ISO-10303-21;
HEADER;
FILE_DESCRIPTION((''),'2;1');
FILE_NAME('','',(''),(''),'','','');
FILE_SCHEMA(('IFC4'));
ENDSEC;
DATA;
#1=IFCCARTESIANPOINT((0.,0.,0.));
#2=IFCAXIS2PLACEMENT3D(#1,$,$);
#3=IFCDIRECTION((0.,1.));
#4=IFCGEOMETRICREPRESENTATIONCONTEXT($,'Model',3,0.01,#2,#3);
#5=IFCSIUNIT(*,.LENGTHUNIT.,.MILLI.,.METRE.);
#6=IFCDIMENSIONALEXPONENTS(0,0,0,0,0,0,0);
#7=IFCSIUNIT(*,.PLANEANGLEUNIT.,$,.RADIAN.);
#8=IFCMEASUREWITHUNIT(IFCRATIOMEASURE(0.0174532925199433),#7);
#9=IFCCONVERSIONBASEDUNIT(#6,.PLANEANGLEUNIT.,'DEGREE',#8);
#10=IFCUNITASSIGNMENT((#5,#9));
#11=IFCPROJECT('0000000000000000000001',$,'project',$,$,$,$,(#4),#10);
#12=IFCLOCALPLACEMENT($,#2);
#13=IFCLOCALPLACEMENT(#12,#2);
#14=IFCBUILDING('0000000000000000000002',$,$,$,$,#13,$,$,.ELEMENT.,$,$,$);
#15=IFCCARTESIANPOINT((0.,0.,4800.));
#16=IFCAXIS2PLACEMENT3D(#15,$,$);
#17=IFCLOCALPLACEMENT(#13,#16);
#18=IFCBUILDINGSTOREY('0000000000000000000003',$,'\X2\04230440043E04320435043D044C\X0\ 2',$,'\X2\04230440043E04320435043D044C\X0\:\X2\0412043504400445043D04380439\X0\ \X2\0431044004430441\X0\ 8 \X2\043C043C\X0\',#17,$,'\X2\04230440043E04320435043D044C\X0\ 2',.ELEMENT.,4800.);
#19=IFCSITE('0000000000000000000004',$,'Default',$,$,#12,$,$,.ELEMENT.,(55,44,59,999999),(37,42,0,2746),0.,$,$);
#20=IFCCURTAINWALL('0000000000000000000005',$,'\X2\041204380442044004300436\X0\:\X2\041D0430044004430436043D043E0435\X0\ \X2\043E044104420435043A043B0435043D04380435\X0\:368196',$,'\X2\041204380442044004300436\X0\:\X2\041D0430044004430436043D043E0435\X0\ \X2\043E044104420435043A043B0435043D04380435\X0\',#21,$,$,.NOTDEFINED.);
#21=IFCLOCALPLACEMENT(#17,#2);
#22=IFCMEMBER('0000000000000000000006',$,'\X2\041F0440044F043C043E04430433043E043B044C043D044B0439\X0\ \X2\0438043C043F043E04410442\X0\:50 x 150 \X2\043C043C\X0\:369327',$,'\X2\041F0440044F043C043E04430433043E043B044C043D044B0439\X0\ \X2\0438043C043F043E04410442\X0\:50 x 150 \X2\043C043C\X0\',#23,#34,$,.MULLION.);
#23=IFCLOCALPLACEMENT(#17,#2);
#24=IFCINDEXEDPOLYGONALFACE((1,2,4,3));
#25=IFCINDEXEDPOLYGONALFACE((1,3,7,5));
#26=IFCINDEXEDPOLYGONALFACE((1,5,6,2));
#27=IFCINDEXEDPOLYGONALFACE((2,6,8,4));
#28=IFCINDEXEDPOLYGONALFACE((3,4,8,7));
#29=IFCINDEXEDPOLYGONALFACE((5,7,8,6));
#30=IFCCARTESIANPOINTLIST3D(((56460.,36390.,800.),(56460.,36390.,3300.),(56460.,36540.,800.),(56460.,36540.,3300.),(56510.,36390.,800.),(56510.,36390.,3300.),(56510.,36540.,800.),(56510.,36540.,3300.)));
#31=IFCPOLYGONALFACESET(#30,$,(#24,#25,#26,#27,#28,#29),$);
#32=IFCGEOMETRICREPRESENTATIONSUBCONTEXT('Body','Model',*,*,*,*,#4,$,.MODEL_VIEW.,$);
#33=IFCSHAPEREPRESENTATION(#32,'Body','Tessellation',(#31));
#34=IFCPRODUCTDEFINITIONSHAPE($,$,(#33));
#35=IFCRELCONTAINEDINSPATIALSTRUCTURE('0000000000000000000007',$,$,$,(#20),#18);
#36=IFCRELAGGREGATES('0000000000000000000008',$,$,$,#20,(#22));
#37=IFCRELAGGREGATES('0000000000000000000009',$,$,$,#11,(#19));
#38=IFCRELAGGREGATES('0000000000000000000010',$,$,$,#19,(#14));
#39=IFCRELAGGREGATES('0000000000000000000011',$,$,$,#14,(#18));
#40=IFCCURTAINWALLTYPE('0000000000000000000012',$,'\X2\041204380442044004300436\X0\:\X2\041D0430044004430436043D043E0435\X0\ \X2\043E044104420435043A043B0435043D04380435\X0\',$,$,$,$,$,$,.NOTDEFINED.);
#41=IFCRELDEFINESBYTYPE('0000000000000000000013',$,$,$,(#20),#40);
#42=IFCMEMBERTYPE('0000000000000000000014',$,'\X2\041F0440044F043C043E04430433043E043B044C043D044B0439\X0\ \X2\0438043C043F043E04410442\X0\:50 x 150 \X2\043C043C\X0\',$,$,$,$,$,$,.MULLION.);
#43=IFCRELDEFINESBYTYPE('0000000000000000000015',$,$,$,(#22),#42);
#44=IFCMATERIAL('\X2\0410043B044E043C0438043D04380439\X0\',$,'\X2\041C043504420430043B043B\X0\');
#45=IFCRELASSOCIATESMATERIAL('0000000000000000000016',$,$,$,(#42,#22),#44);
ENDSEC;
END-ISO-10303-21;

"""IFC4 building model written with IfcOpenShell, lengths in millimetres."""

from ifc_helpers import new_model, entity, si_unit, converted_unit, direction, frame, origin, origin_2d_with_axis, place, context, subcontext, project, spatial, rectangle, extrude, source, transform, mapped, material, material_profile, profile_set, profile_usage, type_object, type_shapes, element, aggregate, save


model = new_model("IFC4")

# Units and contexts
model_context = context("Model", 3, precision=0.01, world=origin(), true_north=direction((0.0, 1.0)))
body_context = subcontext(model_context, "Body", "Model", "MODEL_VIEW")
ifc_project = project(units=[si_unit("LENGTHUNIT", "METRE", prefix="MILLI"), converted_unit("PLANEANGLEUNIT", "DEGREE", entity("IfcRatioMeasure", 0.0174532925199433), si_unit("PLANEANGLEUNIT", "RADIAN"), dimensions=[0, 0, 0, 0, 0, 0, 0])], contexts=[model_context])

# Site, building, storey
site_placement = place(None, origin())
site = spatial("IfcSite", under=ifc_project, at=site_placement, Name="Default", CompositionType="ELEMENT", RefLatitude=(55, 44, 59, 999999), RefLongitude=(37, 42, 0, 2746), RefElevation=0.0)
building_placement = place(site_placement, origin())
building = spatial("IfcBuilding", under=site, at=building_placement, CompositionType="ELEMENT")
storey_placement = place(building_placement, frame((0.0, 0.0, 4800.0)))
storey = spatial("IfcBuildingStorey", under=building, at=storey_placement, Name="Уровень 2", ObjectType="Уровень:Верхний брус 8 мм", LongName="Уровень 2", CompositionType="ELEMENT", Elevation=4800.0)

# Curtain wall, member
curtain_wall_type = type_object("IfcCurtainWallType", Name="Витраж:Наружное остекление", PredefinedType="NOTDEFINED")
curtain_wall_placement = place(storey_placement, frame((0.0, 0.0, -4800.0)))
curtain_wall = element("IfcCurtainWall", 1, at=curtain_wall_placement, inside=storey, type_object=curtain_wall_type, Name="Витраж:Наружное остекление:368196", ObjectType="Витраж:Наружное остекление", PredefinedType="NOTDEFINED")
ifc_material_1 = material(Name="Алюминий", Category="Металл")
ifc_material_profile = material_profile(ifc_material_1, rectangle(XDim=150.0, YDim=50.0, at=origin_2d_with_axis()), Name="50 x 150 мм")
ifc_profile_set = profile_set([ifc_material_profile], Name="50 x 150 мм")
member_type_1 = type_object("IfcMemberType", Name="Прямоугольный импост:50 x 150 мм", PredefinedType="MULLION", material=ifc_profile_set)
shared_shape_1 = source(origin(), body_context, "Body", "SweptSolid", [
    extrude(rectangle(XDim=150.0, YDim=50.0, at=origin_2d_with_axis()), frame((0.0, 0.0, -2500.0), z_axis=(0.0, 0.0, 1.0), x_axis=(0.0, -1.0, 0.0)), (0.0, 0.0, 1.0), 2500.0),
])
type_shapes(member_type_1, [shared_shape_1])
ifc_profile_usage_1 = profile_usage(ifc_profile_set)
member_1_placement = place(storey_placement, frame((56485.0, 36465.0, 800.0), z_axis=(0.0, 0.0, -1.0), x_axis=(-1.0, 0.0, 0.0)))
member_1 = element("IfcMember", 2, at=member_1_placement, type_object=member_type_1, material=ifc_profile_usage_1, Name="Прямоугольный импост:50 x 150 мм:369327", ObjectType="Прямоугольный импост:50 x 150 мм", PredefinedType="MULLION", context=body_context, shape_type="MappedRepresentation", body=[
    mapped(shared_shape_1, transform((0.0, 0.0, 0.0), scale=1.0)),
])
aggregate(curtain_wall, [member_1])

save(model, "model.ifc")
